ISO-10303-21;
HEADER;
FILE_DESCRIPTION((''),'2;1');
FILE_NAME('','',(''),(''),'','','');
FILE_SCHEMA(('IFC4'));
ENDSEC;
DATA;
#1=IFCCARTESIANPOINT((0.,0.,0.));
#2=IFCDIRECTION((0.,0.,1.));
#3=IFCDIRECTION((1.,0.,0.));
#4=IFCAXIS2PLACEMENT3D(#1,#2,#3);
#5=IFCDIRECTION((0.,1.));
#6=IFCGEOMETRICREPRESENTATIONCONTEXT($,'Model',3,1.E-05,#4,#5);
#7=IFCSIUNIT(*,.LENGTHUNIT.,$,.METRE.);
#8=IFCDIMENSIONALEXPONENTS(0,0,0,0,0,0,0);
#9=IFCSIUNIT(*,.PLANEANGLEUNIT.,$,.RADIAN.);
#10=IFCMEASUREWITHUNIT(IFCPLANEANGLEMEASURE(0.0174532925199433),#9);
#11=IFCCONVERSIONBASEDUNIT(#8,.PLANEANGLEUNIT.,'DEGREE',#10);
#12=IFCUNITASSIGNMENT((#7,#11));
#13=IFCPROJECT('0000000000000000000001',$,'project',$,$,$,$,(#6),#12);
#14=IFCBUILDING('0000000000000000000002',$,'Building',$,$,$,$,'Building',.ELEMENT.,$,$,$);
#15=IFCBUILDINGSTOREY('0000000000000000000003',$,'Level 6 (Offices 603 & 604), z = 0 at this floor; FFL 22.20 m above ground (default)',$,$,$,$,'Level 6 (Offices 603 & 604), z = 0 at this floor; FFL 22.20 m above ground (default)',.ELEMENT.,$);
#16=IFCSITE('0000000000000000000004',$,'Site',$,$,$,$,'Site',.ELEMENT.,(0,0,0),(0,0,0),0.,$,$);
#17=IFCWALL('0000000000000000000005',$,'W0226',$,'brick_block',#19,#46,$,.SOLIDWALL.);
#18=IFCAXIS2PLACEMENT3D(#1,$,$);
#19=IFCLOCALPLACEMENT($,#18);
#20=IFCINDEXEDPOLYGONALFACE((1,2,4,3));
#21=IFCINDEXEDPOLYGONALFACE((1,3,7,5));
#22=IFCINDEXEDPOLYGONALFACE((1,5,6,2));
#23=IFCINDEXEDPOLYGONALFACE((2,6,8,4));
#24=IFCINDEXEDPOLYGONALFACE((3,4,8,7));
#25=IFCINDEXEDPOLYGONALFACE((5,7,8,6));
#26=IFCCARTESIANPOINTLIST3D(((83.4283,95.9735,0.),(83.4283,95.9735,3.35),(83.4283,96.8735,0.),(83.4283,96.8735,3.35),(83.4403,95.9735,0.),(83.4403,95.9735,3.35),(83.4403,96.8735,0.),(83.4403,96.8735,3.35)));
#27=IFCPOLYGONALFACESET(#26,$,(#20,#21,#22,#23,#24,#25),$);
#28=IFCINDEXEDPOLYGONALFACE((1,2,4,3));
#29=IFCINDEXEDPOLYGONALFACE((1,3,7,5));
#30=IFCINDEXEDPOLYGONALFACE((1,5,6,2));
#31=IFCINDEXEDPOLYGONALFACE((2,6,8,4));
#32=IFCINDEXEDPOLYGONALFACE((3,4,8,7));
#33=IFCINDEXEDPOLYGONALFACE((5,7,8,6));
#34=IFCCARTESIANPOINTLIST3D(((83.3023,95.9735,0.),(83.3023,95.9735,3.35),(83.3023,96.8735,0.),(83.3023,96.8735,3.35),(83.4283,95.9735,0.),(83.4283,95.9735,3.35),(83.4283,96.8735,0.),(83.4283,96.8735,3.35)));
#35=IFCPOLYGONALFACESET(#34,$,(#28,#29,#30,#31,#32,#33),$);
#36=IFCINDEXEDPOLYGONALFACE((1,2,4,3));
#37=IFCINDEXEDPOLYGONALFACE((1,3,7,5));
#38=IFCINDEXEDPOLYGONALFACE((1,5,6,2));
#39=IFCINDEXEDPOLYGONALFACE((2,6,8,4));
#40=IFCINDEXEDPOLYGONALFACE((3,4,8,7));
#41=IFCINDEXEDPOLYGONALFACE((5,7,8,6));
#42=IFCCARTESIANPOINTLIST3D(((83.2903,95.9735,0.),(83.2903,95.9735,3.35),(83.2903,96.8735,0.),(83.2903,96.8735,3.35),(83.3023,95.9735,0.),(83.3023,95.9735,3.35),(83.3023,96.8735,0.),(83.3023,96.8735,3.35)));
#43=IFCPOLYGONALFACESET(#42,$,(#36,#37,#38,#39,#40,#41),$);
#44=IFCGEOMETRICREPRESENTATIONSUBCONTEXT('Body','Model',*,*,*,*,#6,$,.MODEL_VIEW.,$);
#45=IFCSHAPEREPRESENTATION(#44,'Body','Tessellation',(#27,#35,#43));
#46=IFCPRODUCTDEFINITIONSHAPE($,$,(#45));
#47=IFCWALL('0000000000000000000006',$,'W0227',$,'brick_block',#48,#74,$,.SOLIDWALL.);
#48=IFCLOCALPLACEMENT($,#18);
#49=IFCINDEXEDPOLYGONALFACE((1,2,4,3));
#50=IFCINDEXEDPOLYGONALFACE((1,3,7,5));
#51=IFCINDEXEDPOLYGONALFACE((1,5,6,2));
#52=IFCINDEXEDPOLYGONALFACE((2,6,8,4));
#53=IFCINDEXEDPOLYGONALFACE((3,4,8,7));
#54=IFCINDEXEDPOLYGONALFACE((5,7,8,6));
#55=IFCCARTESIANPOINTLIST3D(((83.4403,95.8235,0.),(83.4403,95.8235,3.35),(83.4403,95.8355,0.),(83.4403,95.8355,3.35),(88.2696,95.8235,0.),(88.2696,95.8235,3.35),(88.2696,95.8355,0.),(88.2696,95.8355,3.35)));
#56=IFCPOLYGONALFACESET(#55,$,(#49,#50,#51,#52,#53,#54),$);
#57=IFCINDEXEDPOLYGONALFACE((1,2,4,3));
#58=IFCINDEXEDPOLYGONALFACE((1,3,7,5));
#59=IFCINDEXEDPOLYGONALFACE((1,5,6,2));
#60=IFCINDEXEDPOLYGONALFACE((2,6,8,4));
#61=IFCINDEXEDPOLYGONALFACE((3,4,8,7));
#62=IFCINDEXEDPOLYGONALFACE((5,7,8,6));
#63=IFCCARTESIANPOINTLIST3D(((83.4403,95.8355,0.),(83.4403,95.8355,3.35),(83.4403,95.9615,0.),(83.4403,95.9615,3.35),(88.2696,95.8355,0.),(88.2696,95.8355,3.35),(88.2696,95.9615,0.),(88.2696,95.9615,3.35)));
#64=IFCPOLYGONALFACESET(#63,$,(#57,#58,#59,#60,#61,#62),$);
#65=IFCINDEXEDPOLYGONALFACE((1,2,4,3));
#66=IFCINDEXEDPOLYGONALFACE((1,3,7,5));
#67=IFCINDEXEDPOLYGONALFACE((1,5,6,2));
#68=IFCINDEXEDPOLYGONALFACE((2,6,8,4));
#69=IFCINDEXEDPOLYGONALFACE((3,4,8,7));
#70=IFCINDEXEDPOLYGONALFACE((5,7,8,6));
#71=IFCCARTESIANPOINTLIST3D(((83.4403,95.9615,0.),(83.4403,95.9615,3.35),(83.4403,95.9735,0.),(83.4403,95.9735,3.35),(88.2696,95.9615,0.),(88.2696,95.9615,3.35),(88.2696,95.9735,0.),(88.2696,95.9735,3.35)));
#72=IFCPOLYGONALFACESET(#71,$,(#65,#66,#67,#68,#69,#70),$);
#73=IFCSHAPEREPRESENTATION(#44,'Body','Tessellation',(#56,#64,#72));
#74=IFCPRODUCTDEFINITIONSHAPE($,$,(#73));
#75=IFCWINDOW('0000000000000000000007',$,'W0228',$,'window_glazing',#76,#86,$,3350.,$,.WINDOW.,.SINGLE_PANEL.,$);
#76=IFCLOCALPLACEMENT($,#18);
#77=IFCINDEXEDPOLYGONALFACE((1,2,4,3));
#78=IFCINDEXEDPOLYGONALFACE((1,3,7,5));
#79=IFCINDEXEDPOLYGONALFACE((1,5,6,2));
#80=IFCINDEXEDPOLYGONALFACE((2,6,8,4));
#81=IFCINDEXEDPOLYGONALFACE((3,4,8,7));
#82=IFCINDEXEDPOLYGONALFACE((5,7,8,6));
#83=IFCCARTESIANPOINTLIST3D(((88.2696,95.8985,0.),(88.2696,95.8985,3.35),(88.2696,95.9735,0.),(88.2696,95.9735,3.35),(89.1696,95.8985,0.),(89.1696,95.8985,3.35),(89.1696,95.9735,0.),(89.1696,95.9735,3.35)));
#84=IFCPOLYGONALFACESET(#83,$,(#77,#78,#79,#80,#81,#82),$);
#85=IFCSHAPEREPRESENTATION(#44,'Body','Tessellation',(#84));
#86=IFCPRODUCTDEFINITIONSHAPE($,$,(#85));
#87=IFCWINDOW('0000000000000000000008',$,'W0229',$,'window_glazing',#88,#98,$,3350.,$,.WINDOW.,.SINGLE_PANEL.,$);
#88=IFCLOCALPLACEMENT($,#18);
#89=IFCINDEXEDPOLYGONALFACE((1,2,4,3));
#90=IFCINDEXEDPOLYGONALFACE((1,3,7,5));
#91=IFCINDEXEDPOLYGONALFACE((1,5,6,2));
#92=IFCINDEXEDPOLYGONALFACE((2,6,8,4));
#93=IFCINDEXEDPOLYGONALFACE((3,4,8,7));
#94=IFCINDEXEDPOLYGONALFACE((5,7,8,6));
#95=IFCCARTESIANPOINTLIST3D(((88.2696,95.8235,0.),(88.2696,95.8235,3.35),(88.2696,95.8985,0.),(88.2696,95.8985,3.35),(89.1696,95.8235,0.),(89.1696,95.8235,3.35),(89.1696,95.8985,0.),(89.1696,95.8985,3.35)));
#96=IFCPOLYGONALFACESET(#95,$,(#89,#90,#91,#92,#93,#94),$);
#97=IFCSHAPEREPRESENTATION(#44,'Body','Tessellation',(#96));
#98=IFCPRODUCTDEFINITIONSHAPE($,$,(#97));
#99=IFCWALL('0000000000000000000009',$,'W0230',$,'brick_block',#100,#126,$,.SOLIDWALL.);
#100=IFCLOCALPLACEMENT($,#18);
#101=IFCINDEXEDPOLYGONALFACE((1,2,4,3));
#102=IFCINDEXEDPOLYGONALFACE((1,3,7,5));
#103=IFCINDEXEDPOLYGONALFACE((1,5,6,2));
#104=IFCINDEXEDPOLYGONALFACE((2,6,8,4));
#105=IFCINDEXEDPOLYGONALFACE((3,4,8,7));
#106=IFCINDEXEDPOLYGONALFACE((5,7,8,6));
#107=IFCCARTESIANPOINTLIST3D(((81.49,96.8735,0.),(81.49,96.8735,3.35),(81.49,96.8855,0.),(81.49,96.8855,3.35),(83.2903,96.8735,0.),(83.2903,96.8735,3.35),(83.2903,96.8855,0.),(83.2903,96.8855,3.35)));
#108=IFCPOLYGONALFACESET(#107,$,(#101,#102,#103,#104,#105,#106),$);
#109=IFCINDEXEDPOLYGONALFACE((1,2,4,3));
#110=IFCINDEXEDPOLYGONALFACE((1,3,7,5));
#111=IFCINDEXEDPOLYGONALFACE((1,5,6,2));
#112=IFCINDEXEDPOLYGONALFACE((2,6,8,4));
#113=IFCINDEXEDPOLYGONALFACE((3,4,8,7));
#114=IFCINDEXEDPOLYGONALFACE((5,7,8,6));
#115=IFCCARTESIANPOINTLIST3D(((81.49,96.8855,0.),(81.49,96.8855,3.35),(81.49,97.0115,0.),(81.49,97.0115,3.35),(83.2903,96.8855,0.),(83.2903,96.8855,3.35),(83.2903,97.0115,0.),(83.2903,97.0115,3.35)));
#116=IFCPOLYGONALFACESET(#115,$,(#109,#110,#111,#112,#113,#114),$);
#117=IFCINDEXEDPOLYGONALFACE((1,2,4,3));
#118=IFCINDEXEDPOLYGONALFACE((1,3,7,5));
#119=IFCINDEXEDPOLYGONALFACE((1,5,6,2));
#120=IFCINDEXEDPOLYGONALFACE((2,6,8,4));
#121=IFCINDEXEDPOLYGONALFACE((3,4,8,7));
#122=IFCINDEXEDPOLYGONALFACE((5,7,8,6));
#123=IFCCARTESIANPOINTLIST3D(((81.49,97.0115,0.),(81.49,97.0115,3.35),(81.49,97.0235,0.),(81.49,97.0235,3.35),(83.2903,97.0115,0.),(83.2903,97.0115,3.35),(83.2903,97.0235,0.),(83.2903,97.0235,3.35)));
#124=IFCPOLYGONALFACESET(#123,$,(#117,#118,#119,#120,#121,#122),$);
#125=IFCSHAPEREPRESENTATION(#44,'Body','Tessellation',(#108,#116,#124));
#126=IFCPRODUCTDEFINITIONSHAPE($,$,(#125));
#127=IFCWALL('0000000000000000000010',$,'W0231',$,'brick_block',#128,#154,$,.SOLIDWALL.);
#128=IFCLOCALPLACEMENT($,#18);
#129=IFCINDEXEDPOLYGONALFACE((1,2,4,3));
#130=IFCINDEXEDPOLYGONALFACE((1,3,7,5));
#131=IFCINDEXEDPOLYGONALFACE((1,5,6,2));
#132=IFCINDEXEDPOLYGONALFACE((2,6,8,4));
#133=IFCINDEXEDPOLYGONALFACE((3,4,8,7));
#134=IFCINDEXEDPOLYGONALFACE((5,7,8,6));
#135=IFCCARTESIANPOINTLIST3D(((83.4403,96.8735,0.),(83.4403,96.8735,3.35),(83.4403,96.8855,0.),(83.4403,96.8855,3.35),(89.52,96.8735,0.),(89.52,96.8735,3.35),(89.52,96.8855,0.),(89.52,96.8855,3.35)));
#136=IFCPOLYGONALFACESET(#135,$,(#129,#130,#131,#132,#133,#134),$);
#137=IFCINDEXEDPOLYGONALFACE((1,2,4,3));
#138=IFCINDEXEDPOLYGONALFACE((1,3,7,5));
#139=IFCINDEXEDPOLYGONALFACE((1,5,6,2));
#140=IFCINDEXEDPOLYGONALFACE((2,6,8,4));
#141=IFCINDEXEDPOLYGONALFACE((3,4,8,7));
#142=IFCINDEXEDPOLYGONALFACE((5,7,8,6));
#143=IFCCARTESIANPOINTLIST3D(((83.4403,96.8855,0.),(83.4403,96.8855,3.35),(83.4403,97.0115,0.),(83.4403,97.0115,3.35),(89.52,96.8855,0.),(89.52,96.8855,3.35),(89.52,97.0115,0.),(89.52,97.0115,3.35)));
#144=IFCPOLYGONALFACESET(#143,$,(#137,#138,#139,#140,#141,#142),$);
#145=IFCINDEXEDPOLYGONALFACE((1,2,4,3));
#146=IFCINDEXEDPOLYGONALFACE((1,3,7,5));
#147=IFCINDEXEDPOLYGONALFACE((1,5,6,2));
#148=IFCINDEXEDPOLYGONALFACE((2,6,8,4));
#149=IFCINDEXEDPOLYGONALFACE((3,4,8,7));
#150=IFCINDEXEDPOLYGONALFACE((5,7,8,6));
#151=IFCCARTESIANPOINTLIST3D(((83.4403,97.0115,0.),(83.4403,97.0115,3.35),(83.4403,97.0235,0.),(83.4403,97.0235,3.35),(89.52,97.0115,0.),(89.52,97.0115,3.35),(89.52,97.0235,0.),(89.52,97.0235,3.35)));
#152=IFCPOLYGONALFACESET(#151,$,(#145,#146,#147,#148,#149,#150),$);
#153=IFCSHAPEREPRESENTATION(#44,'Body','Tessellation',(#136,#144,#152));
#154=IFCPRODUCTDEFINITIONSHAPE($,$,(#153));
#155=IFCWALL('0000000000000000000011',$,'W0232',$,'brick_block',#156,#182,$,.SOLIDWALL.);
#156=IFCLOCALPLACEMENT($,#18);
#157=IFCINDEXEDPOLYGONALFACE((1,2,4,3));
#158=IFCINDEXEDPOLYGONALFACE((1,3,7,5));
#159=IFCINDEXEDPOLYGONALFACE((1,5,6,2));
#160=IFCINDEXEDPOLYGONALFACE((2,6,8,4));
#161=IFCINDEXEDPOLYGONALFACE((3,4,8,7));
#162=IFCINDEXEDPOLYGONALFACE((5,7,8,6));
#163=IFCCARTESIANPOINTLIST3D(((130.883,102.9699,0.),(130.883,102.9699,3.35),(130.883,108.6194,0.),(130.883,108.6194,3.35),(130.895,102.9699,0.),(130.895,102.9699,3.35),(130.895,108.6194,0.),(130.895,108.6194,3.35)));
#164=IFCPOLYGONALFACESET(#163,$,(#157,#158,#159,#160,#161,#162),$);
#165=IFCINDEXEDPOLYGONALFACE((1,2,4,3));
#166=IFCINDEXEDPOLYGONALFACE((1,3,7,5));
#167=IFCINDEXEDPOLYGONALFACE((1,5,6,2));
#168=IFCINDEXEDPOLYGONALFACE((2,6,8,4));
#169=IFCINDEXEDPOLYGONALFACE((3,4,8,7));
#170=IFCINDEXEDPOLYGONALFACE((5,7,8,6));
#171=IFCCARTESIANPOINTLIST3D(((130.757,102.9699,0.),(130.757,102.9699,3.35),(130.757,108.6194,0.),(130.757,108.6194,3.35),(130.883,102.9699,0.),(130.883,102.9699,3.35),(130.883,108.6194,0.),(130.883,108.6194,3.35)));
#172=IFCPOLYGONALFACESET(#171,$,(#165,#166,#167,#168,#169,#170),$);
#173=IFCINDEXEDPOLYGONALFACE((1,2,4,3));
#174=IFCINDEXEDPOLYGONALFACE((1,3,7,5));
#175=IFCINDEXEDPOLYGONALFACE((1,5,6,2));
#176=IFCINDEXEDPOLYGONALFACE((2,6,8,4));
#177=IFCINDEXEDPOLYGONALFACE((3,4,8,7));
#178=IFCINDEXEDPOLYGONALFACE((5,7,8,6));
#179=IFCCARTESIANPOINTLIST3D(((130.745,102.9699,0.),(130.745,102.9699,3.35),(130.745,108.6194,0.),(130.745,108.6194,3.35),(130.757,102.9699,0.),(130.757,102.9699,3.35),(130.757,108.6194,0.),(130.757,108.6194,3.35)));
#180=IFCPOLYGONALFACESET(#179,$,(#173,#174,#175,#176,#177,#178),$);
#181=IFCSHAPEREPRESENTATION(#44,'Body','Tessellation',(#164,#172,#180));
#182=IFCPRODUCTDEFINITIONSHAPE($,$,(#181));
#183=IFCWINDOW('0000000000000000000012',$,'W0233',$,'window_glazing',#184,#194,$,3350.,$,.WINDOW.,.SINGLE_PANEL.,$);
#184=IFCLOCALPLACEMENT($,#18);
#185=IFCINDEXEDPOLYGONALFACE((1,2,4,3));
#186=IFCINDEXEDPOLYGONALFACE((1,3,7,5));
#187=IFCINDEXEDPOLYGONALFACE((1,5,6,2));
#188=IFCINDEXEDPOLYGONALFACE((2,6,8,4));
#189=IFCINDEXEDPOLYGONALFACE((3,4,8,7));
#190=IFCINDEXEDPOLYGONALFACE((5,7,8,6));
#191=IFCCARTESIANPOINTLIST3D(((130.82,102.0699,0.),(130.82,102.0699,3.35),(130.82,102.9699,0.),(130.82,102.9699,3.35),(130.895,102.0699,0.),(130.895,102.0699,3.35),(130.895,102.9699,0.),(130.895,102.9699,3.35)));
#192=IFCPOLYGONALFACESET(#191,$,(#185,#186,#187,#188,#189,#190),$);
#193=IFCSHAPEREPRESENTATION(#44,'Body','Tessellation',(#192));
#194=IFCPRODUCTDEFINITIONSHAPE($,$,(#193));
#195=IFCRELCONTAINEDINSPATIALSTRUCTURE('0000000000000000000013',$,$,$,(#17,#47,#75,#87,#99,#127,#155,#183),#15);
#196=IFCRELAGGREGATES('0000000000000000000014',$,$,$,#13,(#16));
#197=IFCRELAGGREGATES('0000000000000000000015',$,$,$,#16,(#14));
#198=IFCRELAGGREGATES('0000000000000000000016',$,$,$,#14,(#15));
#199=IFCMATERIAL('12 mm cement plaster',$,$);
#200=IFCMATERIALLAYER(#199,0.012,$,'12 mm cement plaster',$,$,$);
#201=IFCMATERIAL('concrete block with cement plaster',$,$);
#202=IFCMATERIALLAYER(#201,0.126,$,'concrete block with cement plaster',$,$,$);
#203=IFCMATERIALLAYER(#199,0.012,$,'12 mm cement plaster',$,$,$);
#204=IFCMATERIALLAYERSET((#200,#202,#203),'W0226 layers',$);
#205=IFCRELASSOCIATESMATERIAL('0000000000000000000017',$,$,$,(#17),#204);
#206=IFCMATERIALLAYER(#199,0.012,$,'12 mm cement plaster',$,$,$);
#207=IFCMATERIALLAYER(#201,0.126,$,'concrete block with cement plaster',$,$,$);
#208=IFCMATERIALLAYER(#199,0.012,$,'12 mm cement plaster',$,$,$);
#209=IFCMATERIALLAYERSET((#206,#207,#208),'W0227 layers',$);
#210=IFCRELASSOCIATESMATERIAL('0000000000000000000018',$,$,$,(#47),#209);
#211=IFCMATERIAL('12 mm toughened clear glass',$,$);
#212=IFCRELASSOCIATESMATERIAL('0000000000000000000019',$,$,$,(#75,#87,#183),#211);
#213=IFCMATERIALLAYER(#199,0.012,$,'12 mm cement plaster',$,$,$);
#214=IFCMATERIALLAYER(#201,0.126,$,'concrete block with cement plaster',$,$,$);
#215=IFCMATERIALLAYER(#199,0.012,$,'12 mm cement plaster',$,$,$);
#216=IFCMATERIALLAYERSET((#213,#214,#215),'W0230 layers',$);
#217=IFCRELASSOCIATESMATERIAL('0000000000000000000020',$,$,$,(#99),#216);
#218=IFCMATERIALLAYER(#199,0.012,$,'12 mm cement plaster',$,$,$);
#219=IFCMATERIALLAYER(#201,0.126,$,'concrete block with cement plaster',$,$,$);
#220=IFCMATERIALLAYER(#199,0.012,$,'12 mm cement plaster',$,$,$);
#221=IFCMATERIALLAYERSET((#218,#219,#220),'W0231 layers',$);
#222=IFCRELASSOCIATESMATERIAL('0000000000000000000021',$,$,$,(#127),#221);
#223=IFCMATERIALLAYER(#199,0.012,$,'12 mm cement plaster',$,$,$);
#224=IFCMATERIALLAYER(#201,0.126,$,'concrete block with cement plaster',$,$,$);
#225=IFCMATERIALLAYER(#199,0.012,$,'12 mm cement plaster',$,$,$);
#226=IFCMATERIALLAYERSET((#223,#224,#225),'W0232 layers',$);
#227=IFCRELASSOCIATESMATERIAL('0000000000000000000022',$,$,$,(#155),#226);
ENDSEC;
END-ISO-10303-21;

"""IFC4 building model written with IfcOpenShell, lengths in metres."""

from ifc_helpers import new_model, entity, si_unit, converted_unit, direction, frame, frame_2d, origin_with_axes, origin_2d_with_axis, place, context, subcontext, project, spatial, rectangle, extrude, material, layer, layer_set, layer_usage, element, save


model = new_model("IFC4")

# Units and contexts
model_context = context("Model", 3, precision=1e-05, world=origin_with_axes(), true_north=direction((0.0, 1.0)))
body_context = subcontext(model_context, "Body", "Model", "MODEL_VIEW")
ifc_project = project(units=[si_unit("LENGTHUNIT", "METRE"), converted_unit("PLANEANGLEUNIT", "DEGREE", entity("IfcPlaneAngleMeasure", 0.0174532925199433), si_unit("PLANEANGLEUNIT", "RADIAN"), dimensions=[0, 0, 0, 0, 0, 0, 0])], contexts=[model_context])

# Site, building, storey
site = spatial("IfcSite", under=ifc_project, Name="Site", LongName="Site", CompositionType="ELEMENT", RefLatitude=(0, 0, 0), RefLongitude=(0, 0, 0), RefElevation=0.0)
building = spatial("IfcBuilding", under=site, Name="Building", LongName="Building", CompositionType="ELEMENT")
storey = spatial("IfcBuildingStorey", under=building, Name="Level 6 (Offices 603 & 604), z = 0 at this floor; FFL 22.20 m above ground (default)", LongName="Level 6 (Offices 603 & 604), z = 0 at this floor; FFL 22.20 m above ground (default)", CompositionType="ELEMENT")

# Shared definitions
ifc_material_1 = material(Name="12 mm cement plaster")
ifc_material_2 = material(Name="concrete block with cement plaster")
placement = place(None, origin_with_axes())

# Shared definitions
ifc_material_3 = material(Name="12 mm toughened clear glass")

# Walls
ifc_layer_1 = layer(ifc_material_1, 0.012, Name="12 mm cement plaster")
ifc_layer_2 = layer(ifc_material_2, 0.126, Name="concrete block with cement plaster")
ifc_layer_3 = layer(ifc_material_1, 0.012, Name="12 mm cement plaster")
ifc_layer_set_1 = layer_set([ifc_layer_1, ifc_layer_2, ifc_layer_3], Name="W0226 layers")
ifc_layer_usage_1 = layer_usage(ifc_layer_set_1, "AXIS2", "POSITIVE", -0.075)
element("IfcWall", 1, at=placement, inside=storey, material=ifc_layer_usage_1, Name="W0226", ObjectType="brick_block", PredefinedType="SOLIDWALL", context=body_context, shape_type="SweptSolid", body=[
    extrude(rectangle(XDim=0.9, YDim=0.012, at=frame_2d((0.0, 0.0), x_axis=(0.0, 1.0))), frame((83.4343, 96.4235, 0.0), z_axis=(0.0, 0.0, 1.0), x_axis=(1.0, 0.0, 0.0)), (0.0, 0.0, 1.0), 3.35),
    extrude(rectangle(XDim=0.9, YDim=0.126, at=frame_2d((-0.069, 0.0), x_axis=(0.0, 1.0))), frame((83.4343, 96.4235, 0.0), z_axis=(0.0, 0.0, 1.0), x_axis=(1.0, 0.0, 0.0)), (0.0, 0.0, 1.0), 3.35),
    extrude(rectangle(XDim=0.9, YDim=0.012, at=frame_2d((-0.138, 0.0), x_axis=(0.0, 1.0))), frame((83.4343, 96.4235, 0.0), z_axis=(0.0, 0.0, 1.0), x_axis=(1.0, 0.0, 0.0)), (0.0, 0.0, 1.0), 3.35),
])
ifc_layer_4 = layer(ifc_material_1, 0.012, Name="12 mm cement plaster")
ifc_layer_5 = layer(ifc_material_2, 0.126, Name="concrete block with cement plaster")
ifc_layer_6 = layer(ifc_material_1, 0.012, Name="12 mm cement plaster")
ifc_layer_set_2 = layer_set([ifc_layer_4, ifc_layer_5, ifc_layer_6], Name="W0227 layers")
ifc_layer_usage_2 = layer_usage(ifc_layer_set_2, "AXIS2", "POSITIVE", -0.075)
element("IfcWall", 2, at=placement, inside=storey, material=ifc_layer_usage_2, Name="W0227", ObjectType="brick_block", PredefinedType="SOLIDWALL", context=body_context, shape_type="SweptSolid", body=[
    extrude(rectangle(XDim=4.8293, YDim=0.012, at=frame_2d((0.0, 0.0), x_axis=(1.0, 0.0))), frame((85.855, 95.8295, 0.0), z_axis=(0.0, 0.0, 1.0), x_axis=(1.0, 0.0, 0.0)), (0.0, 0.0, 1.0), 3.35),
    extrude(rectangle(XDim=4.8293, YDim=0.126, at=frame_2d((0.0, 0.069), x_axis=(1.0, 0.0))), frame((85.855, 95.8295, 0.0), z_axis=(0.0, 0.0, 1.0), x_axis=(1.0, 0.0, 0.0)), (0.0, 0.0, 1.0), 3.35),
    extrude(rectangle(XDim=4.8293, YDim=0.012, at=frame_2d((0.0, 0.138), x_axis=(1.0, 0.0))), frame((85.855, 95.8295, 0.0), z_axis=(0.0, 0.0, 1.0), x_axis=(1.0, 0.0, 0.0)), (0.0, 0.0, 1.0), 3.35),
])

# Windows
element("IfcWindow", 3, at=placement, inside=storey, material=ifc_material_3, Name="W0228", ObjectType="window_glazing", OverallHeight=3350.0, PartitioningType="SINGLE_PANEL", PredefinedType="WINDOW", context=body_context, shape_type="SweptSolid", body=[
    extrude(rectangle(XDim=0.9, YDim=0.075, at=frame_2d((0.0, 0.0), x_axis=(1.0, 0.0))), frame((88.7196, 95.936, 0.0), z_axis=(0.0, 0.0, 1.0), x_axis=(1.0, 0.0, 0.0)), (0.0, 0.0, 1.0), 3.35),
])
element("IfcWindow", 4, at=placement, inside=storey, material=ifc_material_3, Name="W0229", ObjectType="window_glazing", OverallHeight=3350.0, PartitioningType="SINGLE_PANEL", PredefinedType="WINDOW", context=body_context, shape_type="SweptSolid", body=[
    extrude(rectangle(XDim=0.9, YDim=0.075, at=frame_2d((0.0, 0.0), x_axis=(1.0, 0.0))), frame((88.7196, 95.861, 0.0), z_axis=(0.0, 0.0, 1.0), x_axis=(1.0, 0.0, 0.0)), (0.0, 0.0, 1.0), 3.35),
])

# Walls
ifc_layer_7 = layer(ifc_material_1, 0.012, Name="12 mm cement plaster")
ifc_layer_8 = layer(ifc_material_2, 0.126, Name="concrete block with cement plaster")
ifc_layer_9 = layer(ifc_material_1, 0.012, Name="12 mm cement plaster")
ifc_layer_set_3 = layer_set([ifc_layer_7, ifc_layer_8, ifc_layer_9], Name="W0230 layers")
ifc_layer_usage_3 = layer_usage(ifc_layer_set_3, "AXIS2", "POSITIVE", -0.075)
element("IfcWall", 5, at=placement, inside=storey, material=ifc_layer_usage_3, Name="W0230", ObjectType="brick_block", PredefinedType="SOLIDWALL", context=body_context, shape_type="SweptSolid", body=[
    extrude(rectangle(XDim=1.8003, YDim=0.012, at=frame_2d((0.0, 0.0), x_axis=(1.0, 0.0))), frame((82.3902, 96.8795, 0.0), z_axis=(0.0, 0.0, 1.0), x_axis=(1.0, 0.0, 0.0)), (0.0, 0.0, 1.0), 3.35),
    extrude(rectangle(XDim=1.8003, YDim=0.126, at=frame_2d((0.0, 0.069), x_axis=(1.0, 0.0))), frame((82.3902, 96.8795, 0.0), z_axis=(0.0, 0.0, 1.0), x_axis=(1.0, 0.0, 0.0)), (0.0, 0.0, 1.0), 3.35),
    extrude(rectangle(XDim=1.8003, YDim=0.012, at=frame_2d((0.0, 0.138), x_axis=(1.0, 0.0))), frame((82.3902, 96.8795, 0.0), z_axis=(0.0, 0.0, 1.0), x_axis=(1.0, 0.0, 0.0)), (0.0, 0.0, 1.0), 3.35),
])
ifc_layer_10 = layer(ifc_material_1, 0.012, Name="12 mm cement plaster")
ifc_layer_11 = layer(ifc_material_2, 0.126, Name="concrete block with cement plaster")
ifc_layer_12 = layer(ifc_material_1, 0.012, Name="12 mm cement plaster")
ifc_layer_set_4 = layer_set([ifc_layer_10, ifc_layer_11, ifc_layer_12], Name="W0231 layers")
ifc_layer_usage_4 = layer_usage(ifc_layer_set_4, "AXIS2", "POSITIVE", -0.075)
element("IfcWall", 6, at=placement, inside=storey, material=ifc_layer_usage_4, Name="W0231", ObjectType="brick_block", PredefinedType="SOLIDWALL", context=body_context, shape_type="SweptSolid", body=[
    extrude(rectangle(XDim=6.0797, YDim=0.012, at=origin_2d_with_axis()), frame((86.4801, 96.8795, 0.0), z_axis=(0.0, 0.0, 1.0), x_axis=(1.0, 0.0, 0.0)), (0.0, 0.0, 1.0), 3.35),
    extrude(rectangle(XDim=6.0797, YDim=0.126, at=frame_2d((0.0, 0.069), x_axis=(1.0, 0.0))), frame((86.4801, 96.8795, 0.0), z_axis=(0.0, 0.0, 1.0), x_axis=(1.0, 0.0, 0.0)), (0.0, 0.0, 1.0), 3.35),
    extrude(rectangle(XDim=6.0797, YDim=0.012, at=frame_2d((0.0, 0.138), x_axis=(1.0, 0.0))), frame((86.4801, 96.8795, 0.0), z_axis=(0.0, 0.0, 1.0), x_axis=(1.0, 0.0, 0.0)), (0.0, 0.0, 1.0), 3.35),
])
ifc_layer_13 = layer(ifc_material_1, 0.012, Name="12 mm cement plaster")
ifc_layer_14 = layer(ifc_material_2, 0.126, Name="concrete block with cement plaster")
ifc_layer_15 = layer(ifc_material_1, 0.012, Name="12 mm cement plaster")
ifc_layer_set_5 = layer_set([ifc_layer_13, ifc_layer_14, ifc_layer_15], Name="W0232 layers")
ifc_layer_usage_5 = layer_usage(ifc_layer_set_5, "AXIS2", "POSITIVE", -0.075)
element("IfcWall", 7, at=placement, inside=storey, material=ifc_layer_usage_5, Name="W0232", ObjectType="brick_block", PredefinedType="SOLIDWALL", context=body_context, shape_type="SweptSolid", body=[
    extrude(rectangle(XDim=5.6495, YDim=0.012, at=frame_2d((0.0, 0.0), x_axis=(0.0, 1.0))), frame((130.889, 105.7947, 0.0), z_axis=(0.0, 0.0, 1.0), x_axis=(1.0, 0.0, 0.0)), (0.0, 0.0, 1.0), 3.35),
    extrude(rectangle(XDim=5.6495, YDim=0.126, at=frame_2d((-0.069, 0.0), x_axis=(0.0, 1.0))), frame((130.889, 105.7947, 0.0), z_axis=(0.0, 0.0, 1.0), x_axis=(1.0, 0.0, 0.0)), (0.0, 0.0, 1.0), 3.35),
    extrude(rectangle(XDim=5.6495, YDim=0.012, at=frame_2d((-0.138, 0.0), x_axis=(0.0, 1.0))), frame((130.889, 105.7947, 0.0), z_axis=(0.0, 0.0, 1.0), x_axis=(1.0, 0.0, 0.0)), (0.0, 0.0, 1.0), 3.35),
])

# Window
element("IfcWindow", 8, at=placement, inside=storey, material=ifc_material_3, Name="W0233", ObjectType="window_glazing", OverallHeight=3350.0, PartitioningType="SINGLE_PANEL", PredefinedType="WINDOW", context=body_context, shape_type="SweptSolid", body=[
    extrude(rectangle(XDim=0.9, YDim=0.075, at=frame_2d((0.0, 0.0), x_axis=(0.0, 1.0))), frame((130.8575, 102.5199, 0.0), z_axis=(0.0, 0.0, 1.0), x_axis=(1.0, 0.0, 0.0)), (0.0, 0.0, 1.0), 3.35),
])

save(model, "model.ifc")
